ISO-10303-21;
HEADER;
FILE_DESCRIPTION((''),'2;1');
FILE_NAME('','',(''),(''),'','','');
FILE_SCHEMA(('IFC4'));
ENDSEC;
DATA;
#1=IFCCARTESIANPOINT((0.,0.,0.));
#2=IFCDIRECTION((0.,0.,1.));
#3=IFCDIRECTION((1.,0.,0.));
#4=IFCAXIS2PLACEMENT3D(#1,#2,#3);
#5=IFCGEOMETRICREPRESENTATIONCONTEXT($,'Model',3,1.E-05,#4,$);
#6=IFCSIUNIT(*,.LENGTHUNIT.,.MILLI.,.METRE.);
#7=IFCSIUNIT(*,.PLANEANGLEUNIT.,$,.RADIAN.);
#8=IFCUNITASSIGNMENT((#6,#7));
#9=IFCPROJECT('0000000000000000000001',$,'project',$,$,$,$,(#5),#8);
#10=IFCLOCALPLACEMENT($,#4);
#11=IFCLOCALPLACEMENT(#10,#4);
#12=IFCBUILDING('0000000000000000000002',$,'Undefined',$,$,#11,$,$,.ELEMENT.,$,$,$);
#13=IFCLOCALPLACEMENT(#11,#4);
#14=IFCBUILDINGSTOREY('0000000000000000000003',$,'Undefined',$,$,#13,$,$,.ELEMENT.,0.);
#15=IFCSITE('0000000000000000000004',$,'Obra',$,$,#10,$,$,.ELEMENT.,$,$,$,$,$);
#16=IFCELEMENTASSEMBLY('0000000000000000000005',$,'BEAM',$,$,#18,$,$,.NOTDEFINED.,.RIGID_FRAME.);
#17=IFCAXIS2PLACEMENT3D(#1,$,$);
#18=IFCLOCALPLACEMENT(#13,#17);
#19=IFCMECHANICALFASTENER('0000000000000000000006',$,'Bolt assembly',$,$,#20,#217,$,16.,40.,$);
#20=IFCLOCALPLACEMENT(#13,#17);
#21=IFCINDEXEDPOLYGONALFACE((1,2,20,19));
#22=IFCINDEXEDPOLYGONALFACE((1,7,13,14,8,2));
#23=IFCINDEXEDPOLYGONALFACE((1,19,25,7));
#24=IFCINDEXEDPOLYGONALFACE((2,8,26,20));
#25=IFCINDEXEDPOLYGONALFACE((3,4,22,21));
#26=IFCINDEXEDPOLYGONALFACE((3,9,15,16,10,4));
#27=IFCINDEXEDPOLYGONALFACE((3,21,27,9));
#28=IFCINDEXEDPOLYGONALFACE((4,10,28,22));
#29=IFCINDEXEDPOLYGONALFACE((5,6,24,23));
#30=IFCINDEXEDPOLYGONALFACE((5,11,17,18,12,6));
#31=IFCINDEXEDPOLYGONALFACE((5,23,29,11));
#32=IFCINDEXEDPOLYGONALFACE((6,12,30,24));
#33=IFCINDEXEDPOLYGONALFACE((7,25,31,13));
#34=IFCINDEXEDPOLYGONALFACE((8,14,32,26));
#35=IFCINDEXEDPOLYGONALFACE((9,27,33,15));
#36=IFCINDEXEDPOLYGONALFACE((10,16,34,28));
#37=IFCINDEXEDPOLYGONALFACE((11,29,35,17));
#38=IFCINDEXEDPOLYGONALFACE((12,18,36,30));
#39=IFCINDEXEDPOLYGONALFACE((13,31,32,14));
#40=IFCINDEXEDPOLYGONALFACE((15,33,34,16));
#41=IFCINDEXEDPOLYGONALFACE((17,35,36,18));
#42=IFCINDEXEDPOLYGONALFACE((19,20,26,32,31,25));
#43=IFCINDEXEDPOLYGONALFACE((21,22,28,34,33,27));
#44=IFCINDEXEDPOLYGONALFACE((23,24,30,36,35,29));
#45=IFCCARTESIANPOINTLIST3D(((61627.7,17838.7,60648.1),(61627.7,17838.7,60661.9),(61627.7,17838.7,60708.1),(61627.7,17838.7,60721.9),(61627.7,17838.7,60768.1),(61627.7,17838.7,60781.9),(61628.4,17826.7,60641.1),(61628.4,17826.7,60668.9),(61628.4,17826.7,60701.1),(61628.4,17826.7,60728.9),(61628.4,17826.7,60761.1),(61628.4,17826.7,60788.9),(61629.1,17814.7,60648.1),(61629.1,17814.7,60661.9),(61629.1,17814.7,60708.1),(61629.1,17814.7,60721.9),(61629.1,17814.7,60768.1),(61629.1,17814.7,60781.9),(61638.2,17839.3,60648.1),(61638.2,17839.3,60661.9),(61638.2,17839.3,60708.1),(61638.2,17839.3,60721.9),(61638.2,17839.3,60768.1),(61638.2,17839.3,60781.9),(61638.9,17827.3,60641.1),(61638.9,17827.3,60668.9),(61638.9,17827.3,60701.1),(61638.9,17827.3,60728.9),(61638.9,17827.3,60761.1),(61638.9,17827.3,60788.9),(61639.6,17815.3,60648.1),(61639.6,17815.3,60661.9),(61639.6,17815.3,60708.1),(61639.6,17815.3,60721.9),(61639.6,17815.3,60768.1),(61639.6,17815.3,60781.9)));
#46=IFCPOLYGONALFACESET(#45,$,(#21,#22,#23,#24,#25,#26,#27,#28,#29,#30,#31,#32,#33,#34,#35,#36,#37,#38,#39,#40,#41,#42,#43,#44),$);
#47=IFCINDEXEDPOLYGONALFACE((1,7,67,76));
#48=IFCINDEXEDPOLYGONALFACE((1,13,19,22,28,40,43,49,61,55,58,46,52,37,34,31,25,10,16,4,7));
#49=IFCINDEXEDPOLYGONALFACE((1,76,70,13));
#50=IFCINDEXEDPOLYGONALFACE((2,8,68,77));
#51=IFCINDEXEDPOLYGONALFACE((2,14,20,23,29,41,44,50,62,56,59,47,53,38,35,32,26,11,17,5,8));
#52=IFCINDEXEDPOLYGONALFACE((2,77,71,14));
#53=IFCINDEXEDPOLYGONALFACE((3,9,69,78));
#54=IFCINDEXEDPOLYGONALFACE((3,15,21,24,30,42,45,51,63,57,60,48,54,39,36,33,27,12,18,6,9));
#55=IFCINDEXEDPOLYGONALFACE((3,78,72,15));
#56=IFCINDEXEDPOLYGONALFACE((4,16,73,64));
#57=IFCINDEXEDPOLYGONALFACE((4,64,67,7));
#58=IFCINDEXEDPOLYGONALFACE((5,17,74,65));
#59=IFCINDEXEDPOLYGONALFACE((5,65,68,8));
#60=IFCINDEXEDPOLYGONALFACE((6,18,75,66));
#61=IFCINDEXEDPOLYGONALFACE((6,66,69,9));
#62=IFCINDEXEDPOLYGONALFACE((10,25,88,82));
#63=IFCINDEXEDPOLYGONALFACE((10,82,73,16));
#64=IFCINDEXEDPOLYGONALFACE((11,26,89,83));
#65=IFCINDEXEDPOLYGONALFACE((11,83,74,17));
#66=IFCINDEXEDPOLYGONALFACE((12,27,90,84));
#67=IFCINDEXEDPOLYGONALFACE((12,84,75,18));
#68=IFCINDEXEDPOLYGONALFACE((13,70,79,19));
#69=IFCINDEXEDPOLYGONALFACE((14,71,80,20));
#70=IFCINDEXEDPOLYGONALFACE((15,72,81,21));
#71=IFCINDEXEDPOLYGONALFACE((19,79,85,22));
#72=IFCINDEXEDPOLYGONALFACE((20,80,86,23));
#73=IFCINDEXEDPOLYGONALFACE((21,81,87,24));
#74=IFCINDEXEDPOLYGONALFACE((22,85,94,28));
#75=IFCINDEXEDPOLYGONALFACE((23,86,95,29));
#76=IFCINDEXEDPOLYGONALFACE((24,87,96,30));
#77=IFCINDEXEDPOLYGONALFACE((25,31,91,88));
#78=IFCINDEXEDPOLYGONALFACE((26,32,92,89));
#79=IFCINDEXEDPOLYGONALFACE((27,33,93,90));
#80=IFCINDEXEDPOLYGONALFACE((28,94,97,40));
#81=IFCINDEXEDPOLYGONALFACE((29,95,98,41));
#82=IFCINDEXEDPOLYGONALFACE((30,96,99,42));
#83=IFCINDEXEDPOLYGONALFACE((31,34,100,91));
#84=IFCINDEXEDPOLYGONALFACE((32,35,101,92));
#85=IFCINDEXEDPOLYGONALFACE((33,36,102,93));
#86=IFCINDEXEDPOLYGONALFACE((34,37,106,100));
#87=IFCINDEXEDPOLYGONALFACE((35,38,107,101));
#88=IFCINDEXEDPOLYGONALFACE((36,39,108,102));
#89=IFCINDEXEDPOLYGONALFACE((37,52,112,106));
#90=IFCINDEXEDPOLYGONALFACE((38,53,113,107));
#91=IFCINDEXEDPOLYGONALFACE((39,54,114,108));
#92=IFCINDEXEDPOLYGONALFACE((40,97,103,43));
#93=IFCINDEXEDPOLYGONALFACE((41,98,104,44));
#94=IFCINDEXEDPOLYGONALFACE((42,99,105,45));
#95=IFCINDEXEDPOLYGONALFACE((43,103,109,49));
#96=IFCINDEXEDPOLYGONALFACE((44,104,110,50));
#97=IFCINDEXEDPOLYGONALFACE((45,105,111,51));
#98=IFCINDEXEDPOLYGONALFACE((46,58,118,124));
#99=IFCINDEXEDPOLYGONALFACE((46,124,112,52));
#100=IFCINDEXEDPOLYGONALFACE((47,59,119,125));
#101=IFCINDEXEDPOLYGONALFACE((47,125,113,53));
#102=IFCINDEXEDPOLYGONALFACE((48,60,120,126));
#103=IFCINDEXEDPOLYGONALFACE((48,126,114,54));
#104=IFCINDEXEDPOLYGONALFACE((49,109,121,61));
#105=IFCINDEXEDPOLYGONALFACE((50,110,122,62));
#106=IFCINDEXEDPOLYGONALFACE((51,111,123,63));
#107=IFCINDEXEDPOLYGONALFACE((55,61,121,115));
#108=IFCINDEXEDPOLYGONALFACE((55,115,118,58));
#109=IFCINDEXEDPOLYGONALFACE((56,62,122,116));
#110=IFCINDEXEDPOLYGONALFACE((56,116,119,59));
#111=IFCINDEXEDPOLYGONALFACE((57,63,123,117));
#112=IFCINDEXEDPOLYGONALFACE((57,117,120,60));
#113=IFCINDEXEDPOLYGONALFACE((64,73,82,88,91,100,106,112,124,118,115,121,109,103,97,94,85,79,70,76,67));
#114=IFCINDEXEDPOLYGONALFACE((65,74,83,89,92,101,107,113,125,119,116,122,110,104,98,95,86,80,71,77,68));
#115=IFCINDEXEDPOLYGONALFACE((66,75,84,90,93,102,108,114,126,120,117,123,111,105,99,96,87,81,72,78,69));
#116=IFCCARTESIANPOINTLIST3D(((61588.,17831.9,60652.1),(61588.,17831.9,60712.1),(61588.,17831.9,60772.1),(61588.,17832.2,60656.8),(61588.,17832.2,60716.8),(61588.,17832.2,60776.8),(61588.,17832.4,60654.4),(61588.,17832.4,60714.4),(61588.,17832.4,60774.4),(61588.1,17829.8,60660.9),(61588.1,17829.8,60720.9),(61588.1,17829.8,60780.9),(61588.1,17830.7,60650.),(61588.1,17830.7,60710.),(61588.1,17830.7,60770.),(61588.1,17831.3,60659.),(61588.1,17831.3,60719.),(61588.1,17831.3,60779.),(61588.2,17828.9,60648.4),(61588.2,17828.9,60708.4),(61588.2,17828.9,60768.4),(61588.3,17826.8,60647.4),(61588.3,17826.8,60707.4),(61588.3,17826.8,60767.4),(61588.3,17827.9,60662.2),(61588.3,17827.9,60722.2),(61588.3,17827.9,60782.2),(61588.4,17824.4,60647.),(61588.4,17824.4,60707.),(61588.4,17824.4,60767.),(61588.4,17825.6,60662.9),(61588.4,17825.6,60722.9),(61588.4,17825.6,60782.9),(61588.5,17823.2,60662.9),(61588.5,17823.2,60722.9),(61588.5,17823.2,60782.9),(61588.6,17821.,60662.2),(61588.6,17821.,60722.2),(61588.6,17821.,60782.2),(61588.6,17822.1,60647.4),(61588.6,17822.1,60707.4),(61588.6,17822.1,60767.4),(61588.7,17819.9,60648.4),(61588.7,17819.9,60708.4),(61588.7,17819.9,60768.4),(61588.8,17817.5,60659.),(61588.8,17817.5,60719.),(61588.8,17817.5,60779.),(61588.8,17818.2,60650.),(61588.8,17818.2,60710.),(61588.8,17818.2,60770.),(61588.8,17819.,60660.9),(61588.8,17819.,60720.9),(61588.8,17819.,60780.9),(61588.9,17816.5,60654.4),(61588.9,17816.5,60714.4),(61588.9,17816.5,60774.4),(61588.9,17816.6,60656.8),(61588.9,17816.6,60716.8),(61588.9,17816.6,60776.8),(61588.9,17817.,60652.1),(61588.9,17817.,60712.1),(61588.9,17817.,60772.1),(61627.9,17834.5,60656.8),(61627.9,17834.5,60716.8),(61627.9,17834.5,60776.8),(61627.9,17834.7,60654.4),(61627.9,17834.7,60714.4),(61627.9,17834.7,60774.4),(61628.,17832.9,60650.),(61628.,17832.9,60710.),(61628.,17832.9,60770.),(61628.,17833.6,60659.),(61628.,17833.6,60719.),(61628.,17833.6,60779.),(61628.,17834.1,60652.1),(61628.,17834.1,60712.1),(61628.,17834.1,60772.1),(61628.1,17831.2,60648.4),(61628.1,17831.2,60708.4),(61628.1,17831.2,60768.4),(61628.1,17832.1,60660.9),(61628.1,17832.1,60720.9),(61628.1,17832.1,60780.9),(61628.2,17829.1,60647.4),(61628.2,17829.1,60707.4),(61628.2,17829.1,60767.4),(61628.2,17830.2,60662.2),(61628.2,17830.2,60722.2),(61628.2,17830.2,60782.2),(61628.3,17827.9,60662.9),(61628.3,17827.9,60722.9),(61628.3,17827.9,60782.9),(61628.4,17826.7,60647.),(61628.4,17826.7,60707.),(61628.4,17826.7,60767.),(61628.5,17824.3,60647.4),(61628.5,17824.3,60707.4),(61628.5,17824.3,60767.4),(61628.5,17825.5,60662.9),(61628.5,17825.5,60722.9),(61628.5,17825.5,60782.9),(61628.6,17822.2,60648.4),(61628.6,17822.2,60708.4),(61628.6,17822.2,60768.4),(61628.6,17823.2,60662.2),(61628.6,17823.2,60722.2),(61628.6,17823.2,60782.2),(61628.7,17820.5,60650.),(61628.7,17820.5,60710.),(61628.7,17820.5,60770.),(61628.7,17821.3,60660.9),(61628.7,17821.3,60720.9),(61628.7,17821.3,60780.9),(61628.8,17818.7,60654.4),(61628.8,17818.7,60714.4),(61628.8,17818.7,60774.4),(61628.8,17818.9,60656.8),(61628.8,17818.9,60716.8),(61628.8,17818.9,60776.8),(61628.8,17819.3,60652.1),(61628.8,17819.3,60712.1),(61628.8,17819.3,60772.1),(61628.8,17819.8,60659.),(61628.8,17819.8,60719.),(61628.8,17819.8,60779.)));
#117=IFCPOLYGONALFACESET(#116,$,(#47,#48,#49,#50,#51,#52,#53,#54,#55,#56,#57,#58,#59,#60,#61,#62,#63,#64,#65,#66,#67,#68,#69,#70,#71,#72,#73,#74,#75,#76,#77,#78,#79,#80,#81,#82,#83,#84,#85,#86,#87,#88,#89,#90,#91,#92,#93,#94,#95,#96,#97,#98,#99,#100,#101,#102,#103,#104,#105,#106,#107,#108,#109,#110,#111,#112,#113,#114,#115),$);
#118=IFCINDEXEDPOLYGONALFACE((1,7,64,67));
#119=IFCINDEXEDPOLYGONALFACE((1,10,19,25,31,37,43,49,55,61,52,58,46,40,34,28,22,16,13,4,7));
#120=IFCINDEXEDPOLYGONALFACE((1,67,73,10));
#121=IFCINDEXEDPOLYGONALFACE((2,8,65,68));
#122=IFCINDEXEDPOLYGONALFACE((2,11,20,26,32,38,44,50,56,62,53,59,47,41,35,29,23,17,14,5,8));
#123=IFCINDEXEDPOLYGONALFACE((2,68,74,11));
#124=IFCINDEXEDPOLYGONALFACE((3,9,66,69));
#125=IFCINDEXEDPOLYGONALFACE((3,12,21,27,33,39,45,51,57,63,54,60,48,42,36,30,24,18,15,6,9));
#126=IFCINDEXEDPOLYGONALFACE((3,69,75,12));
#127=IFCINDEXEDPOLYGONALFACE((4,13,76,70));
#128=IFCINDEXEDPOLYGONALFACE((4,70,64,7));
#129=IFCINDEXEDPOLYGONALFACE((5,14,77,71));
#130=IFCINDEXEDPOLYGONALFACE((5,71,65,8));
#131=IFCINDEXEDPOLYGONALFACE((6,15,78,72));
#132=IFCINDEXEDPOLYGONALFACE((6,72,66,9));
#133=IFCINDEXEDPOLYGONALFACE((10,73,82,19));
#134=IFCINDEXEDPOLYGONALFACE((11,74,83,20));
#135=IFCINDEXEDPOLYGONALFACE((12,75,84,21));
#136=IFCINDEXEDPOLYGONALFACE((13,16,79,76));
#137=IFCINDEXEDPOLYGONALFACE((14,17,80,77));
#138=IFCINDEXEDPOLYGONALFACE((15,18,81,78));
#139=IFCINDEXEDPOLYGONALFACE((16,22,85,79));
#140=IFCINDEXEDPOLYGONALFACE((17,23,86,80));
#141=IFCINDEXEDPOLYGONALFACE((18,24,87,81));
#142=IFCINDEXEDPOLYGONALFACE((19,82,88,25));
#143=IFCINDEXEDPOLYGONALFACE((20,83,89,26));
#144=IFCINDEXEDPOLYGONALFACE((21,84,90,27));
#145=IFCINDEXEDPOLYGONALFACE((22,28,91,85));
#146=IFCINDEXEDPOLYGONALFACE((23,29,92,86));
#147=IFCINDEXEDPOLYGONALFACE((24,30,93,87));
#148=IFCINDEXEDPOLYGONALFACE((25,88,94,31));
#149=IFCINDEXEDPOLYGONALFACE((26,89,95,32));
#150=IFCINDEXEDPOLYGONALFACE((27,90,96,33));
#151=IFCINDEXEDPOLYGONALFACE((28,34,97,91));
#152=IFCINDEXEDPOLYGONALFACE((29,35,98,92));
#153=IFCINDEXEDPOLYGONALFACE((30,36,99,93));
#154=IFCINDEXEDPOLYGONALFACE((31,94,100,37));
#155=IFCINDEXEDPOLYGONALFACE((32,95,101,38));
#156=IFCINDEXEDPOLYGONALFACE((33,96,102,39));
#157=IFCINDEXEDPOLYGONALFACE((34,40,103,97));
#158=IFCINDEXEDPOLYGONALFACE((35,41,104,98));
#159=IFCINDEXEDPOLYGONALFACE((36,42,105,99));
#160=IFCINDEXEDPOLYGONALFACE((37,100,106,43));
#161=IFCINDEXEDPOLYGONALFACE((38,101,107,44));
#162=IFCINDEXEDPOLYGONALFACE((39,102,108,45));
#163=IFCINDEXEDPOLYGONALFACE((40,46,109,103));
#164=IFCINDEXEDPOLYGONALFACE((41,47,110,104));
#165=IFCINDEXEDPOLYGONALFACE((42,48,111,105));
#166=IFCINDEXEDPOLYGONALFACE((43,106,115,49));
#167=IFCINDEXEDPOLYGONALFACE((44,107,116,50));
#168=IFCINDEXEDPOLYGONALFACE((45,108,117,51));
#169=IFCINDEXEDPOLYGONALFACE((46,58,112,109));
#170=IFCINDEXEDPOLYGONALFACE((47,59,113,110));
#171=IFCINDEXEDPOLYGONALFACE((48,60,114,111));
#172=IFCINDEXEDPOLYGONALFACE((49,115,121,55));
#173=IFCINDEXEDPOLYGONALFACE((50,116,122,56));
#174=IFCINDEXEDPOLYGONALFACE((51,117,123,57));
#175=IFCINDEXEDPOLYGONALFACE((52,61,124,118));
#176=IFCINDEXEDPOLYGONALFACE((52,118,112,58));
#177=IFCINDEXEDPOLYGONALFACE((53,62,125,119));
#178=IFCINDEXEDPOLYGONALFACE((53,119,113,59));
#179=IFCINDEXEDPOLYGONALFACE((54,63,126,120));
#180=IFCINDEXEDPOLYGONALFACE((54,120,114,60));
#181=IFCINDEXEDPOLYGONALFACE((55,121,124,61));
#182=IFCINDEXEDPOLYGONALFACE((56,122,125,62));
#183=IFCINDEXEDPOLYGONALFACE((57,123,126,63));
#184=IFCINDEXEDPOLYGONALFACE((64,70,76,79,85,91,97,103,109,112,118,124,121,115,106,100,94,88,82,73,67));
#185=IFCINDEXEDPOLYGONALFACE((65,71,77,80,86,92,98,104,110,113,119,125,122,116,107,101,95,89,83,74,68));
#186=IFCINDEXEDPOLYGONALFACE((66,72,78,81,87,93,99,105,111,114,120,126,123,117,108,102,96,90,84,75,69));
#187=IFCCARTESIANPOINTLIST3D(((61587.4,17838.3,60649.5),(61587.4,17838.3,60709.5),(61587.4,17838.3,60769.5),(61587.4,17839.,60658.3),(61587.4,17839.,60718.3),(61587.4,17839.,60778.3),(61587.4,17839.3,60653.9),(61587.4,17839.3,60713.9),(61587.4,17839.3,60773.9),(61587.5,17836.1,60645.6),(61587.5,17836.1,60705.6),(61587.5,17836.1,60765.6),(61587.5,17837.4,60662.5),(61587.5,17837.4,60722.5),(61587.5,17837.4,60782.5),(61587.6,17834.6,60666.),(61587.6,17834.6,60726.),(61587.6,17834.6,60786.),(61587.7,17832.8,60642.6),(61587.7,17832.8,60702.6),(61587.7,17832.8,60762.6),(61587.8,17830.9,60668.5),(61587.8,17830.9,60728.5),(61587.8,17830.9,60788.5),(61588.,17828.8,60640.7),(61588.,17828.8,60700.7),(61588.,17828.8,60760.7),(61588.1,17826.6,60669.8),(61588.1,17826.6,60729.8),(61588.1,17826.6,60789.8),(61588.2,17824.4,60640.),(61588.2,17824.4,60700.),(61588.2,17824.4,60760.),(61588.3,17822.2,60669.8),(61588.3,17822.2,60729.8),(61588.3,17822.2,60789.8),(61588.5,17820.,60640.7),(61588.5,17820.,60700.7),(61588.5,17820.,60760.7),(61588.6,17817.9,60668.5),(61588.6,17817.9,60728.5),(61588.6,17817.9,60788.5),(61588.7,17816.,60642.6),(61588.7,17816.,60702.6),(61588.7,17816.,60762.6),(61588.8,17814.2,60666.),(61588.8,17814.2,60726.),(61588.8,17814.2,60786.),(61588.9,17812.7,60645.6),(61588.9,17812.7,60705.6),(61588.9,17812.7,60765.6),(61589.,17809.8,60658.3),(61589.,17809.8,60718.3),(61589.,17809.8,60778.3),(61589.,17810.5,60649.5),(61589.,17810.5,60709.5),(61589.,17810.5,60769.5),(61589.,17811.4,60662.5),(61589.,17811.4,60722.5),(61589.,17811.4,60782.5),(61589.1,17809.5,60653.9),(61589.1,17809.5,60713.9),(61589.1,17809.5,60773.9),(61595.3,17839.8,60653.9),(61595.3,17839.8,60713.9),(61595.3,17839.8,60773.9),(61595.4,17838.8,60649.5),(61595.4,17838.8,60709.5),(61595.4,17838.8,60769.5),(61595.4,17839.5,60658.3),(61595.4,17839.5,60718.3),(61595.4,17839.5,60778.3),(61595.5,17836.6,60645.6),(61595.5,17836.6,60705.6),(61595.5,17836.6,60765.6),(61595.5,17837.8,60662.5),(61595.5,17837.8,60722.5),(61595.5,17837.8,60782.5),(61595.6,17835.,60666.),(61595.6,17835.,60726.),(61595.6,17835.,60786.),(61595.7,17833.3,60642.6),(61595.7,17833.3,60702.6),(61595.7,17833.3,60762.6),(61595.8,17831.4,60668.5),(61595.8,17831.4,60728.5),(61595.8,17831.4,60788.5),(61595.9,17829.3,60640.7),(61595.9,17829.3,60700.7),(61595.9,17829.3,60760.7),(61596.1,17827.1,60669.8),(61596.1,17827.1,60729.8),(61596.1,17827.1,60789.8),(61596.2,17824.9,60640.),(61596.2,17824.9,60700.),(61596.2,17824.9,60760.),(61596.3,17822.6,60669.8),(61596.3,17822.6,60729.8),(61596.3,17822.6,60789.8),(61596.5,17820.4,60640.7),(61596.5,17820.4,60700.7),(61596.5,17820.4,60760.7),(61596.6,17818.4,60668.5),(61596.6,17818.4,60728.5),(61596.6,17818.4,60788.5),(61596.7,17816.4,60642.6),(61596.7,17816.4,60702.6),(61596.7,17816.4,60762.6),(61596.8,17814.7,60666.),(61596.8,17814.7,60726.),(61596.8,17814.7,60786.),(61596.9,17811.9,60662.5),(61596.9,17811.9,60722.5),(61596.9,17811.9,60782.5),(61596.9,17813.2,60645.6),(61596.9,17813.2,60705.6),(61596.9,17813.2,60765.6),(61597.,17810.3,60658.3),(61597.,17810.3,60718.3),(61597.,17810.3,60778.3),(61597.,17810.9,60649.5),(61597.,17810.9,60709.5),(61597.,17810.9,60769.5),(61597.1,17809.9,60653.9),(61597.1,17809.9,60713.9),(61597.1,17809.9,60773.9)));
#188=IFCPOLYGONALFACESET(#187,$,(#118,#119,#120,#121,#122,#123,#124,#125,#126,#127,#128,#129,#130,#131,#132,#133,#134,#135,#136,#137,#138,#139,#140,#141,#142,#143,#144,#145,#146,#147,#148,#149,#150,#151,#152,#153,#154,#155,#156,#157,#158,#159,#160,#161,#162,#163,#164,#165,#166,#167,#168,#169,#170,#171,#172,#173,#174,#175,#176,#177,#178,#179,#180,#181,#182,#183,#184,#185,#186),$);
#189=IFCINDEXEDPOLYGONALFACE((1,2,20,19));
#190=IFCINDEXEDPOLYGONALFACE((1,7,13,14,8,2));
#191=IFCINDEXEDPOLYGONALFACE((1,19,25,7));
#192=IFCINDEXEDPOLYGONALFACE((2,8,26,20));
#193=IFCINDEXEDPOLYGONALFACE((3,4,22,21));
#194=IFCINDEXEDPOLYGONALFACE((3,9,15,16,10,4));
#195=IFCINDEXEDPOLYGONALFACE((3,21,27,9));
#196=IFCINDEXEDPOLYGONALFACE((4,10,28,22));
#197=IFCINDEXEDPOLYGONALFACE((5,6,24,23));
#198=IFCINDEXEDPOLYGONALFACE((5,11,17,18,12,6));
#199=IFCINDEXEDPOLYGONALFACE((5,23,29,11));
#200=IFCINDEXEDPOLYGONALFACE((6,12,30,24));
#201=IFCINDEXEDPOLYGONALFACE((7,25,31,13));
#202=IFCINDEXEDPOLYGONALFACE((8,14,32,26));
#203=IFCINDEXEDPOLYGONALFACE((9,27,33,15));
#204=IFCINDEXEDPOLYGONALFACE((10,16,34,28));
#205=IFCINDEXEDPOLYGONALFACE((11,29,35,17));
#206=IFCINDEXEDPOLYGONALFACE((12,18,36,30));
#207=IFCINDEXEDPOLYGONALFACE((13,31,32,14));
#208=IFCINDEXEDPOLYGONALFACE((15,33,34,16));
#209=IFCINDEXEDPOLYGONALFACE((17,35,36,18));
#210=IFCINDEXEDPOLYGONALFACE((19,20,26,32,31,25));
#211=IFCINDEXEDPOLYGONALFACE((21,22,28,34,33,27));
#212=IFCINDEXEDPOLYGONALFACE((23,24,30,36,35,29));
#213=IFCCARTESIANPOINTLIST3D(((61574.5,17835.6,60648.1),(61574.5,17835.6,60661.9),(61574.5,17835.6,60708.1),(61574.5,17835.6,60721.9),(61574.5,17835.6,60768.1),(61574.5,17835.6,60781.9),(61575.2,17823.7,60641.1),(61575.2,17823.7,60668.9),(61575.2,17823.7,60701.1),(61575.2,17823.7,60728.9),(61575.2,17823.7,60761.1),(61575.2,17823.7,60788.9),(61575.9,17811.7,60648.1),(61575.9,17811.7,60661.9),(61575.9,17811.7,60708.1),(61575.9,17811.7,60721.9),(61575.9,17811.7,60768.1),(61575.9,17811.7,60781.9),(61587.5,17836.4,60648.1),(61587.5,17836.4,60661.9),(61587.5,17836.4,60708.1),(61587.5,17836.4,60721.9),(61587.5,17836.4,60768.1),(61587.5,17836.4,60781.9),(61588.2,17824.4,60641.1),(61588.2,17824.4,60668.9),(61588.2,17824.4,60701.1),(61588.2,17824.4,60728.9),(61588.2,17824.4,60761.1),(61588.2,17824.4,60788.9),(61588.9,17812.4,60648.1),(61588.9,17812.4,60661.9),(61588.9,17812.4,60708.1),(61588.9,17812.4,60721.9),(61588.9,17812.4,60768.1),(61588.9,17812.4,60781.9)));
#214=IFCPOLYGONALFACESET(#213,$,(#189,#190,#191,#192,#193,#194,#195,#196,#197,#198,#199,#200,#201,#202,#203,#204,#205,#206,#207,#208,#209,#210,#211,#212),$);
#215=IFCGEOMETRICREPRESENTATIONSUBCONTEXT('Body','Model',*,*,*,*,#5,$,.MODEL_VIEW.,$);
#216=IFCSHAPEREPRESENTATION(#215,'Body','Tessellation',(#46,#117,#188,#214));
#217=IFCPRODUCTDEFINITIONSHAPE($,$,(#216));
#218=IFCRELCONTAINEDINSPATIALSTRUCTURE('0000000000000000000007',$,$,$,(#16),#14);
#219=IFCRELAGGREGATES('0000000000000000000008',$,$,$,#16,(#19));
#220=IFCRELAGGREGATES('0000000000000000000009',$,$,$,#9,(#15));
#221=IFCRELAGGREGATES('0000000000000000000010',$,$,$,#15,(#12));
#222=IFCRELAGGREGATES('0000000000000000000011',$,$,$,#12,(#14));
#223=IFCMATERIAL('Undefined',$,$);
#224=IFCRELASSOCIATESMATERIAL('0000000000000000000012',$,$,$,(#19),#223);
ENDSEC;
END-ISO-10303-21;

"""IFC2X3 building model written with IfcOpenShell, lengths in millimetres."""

from ifc_helpers import new_model, si_unit, frame, origin_with_axes, origin_2d_with_axis, place, context, subcontext, project, spatial, polyline, circle, outline, extrude, source, transform, mapped, material, element, aggregate, save


model = new_model("IFC2X3")

# Units and contexts
model_context = context("Model", 3, precision=1e-05, world=origin_with_axes())
body_context = subcontext(model_context, "Body", "Model", "MODEL_VIEW")
ifc_project = project(units=[si_unit("LENGTHUNIT", "METRE", prefix="MILLI"), si_unit("PLANEANGLEUNIT", "RADIAN")], contexts=[model_context])

# Site, building, storey
site_placement = place(None, origin_with_axes())
site = spatial("IfcSite", under=ifc_project, at=site_placement, Name="Obra", CompositionType="ELEMENT")
building_placement = place(site_placement, origin_with_axes())
building = spatial("IfcBuilding", under=site, at=building_placement, Name="Undefined", CompositionType="ELEMENT")
storey_placement = place(building_placement, origin_with_axes())
storey = spatial("IfcBuildingStorey", under=building, at=storey_placement, Name="Undefined", CompositionType="ELEMENT", Elevation=0.0)

# Element assembly, mechanical fastener
ifc_material_1 = material(Name="Undefined")
shared_shape_1 = source(origin_with_axes(), body_context, "Body", "SweptSolid", [
    extrude(outline(polyline([(13.9, 0.0), (6.9, 12.0), (-6.9, 12.0), (-13.9, 0.0), (-6.9, -12.0), (6.9, -12.0), (13.9, 0.0)])), frame((0.0, -45.9, 0.0), z_axis=(0.0, 1.0, 0.0), x_axis=(1.0, 0.0, 0.0)), (0.0, 0.0, 1.0), 10.6),
    extrude(circle(Radius=8.0, at=origin_2d_with_axis()), frame((0.0, -35.3, 0.0), z_axis=(0.0, 1.0, 0.0), x_axis=(1.0, 0.0, 0.0)), (0.0, 0.0, 1.0), 40.0),
    extrude(circle(Radius=15.0, at=origin_2d_with_axis()), frame((0.0, -3.1, 0.0), z_axis=(0.0, 1.0, 0.0), x_axis=(1.0, 0.0, 0.0)), (0.0, 0.0, 1.0), 8.0),
    extrude(outline(polyline([(13.9, 0.0), (6.9, 12.0), (-6.9, 12.0), (-13.9, 0.0), (-6.9, -12.0), (6.9, -12.0), (13.9, 0.0)])), frame((0.0, 4.9, 0.0), z_axis=(0.0, 1.0, 0.0), x_axis=(1.0, 0.0, 0.0)), (0.0, 0.0, 1.0), 13.0),
])
assembly_1_placement = place(storey_placement, origin_with_axes())
assembly_1 = element("IfcElementAssembly", 1, at=assembly_1_placement, inside=storey, Name="BEAM", AssemblyPlace="NOTDEFINED", PredefinedType="RIGID_FRAME")
mechanical_fastener_1_placement = place(assembly_1_placement, frame((61596.0, 17774.8, 60835.0), z_axis=(-0.057107, 0.998368, 0.0), x_axis=(0.0, 0.0, -1.0)))
mechanical_fastener_1 = element("IfcMechanicalFastener", 2, at=mechanical_fastener_1_placement, material=ifc_material_1, Name="Bolt assembly", NominalDiameter=16.0, NominalLength=40.0, context=body_context, shape_type="MappedRepresentation", body=[
    mapped(shared_shape_1, transform((60.0, 0.0, 50.0))),
    mapped(shared_shape_1, transform((120.0, 0.0, 50.0))),
    mapped(shared_shape_1, transform((180.0, 0.0, 50.0))),
])

aggregate(assembly_1, [mechanical_fastener_1])

save(model, "model.ifc")
